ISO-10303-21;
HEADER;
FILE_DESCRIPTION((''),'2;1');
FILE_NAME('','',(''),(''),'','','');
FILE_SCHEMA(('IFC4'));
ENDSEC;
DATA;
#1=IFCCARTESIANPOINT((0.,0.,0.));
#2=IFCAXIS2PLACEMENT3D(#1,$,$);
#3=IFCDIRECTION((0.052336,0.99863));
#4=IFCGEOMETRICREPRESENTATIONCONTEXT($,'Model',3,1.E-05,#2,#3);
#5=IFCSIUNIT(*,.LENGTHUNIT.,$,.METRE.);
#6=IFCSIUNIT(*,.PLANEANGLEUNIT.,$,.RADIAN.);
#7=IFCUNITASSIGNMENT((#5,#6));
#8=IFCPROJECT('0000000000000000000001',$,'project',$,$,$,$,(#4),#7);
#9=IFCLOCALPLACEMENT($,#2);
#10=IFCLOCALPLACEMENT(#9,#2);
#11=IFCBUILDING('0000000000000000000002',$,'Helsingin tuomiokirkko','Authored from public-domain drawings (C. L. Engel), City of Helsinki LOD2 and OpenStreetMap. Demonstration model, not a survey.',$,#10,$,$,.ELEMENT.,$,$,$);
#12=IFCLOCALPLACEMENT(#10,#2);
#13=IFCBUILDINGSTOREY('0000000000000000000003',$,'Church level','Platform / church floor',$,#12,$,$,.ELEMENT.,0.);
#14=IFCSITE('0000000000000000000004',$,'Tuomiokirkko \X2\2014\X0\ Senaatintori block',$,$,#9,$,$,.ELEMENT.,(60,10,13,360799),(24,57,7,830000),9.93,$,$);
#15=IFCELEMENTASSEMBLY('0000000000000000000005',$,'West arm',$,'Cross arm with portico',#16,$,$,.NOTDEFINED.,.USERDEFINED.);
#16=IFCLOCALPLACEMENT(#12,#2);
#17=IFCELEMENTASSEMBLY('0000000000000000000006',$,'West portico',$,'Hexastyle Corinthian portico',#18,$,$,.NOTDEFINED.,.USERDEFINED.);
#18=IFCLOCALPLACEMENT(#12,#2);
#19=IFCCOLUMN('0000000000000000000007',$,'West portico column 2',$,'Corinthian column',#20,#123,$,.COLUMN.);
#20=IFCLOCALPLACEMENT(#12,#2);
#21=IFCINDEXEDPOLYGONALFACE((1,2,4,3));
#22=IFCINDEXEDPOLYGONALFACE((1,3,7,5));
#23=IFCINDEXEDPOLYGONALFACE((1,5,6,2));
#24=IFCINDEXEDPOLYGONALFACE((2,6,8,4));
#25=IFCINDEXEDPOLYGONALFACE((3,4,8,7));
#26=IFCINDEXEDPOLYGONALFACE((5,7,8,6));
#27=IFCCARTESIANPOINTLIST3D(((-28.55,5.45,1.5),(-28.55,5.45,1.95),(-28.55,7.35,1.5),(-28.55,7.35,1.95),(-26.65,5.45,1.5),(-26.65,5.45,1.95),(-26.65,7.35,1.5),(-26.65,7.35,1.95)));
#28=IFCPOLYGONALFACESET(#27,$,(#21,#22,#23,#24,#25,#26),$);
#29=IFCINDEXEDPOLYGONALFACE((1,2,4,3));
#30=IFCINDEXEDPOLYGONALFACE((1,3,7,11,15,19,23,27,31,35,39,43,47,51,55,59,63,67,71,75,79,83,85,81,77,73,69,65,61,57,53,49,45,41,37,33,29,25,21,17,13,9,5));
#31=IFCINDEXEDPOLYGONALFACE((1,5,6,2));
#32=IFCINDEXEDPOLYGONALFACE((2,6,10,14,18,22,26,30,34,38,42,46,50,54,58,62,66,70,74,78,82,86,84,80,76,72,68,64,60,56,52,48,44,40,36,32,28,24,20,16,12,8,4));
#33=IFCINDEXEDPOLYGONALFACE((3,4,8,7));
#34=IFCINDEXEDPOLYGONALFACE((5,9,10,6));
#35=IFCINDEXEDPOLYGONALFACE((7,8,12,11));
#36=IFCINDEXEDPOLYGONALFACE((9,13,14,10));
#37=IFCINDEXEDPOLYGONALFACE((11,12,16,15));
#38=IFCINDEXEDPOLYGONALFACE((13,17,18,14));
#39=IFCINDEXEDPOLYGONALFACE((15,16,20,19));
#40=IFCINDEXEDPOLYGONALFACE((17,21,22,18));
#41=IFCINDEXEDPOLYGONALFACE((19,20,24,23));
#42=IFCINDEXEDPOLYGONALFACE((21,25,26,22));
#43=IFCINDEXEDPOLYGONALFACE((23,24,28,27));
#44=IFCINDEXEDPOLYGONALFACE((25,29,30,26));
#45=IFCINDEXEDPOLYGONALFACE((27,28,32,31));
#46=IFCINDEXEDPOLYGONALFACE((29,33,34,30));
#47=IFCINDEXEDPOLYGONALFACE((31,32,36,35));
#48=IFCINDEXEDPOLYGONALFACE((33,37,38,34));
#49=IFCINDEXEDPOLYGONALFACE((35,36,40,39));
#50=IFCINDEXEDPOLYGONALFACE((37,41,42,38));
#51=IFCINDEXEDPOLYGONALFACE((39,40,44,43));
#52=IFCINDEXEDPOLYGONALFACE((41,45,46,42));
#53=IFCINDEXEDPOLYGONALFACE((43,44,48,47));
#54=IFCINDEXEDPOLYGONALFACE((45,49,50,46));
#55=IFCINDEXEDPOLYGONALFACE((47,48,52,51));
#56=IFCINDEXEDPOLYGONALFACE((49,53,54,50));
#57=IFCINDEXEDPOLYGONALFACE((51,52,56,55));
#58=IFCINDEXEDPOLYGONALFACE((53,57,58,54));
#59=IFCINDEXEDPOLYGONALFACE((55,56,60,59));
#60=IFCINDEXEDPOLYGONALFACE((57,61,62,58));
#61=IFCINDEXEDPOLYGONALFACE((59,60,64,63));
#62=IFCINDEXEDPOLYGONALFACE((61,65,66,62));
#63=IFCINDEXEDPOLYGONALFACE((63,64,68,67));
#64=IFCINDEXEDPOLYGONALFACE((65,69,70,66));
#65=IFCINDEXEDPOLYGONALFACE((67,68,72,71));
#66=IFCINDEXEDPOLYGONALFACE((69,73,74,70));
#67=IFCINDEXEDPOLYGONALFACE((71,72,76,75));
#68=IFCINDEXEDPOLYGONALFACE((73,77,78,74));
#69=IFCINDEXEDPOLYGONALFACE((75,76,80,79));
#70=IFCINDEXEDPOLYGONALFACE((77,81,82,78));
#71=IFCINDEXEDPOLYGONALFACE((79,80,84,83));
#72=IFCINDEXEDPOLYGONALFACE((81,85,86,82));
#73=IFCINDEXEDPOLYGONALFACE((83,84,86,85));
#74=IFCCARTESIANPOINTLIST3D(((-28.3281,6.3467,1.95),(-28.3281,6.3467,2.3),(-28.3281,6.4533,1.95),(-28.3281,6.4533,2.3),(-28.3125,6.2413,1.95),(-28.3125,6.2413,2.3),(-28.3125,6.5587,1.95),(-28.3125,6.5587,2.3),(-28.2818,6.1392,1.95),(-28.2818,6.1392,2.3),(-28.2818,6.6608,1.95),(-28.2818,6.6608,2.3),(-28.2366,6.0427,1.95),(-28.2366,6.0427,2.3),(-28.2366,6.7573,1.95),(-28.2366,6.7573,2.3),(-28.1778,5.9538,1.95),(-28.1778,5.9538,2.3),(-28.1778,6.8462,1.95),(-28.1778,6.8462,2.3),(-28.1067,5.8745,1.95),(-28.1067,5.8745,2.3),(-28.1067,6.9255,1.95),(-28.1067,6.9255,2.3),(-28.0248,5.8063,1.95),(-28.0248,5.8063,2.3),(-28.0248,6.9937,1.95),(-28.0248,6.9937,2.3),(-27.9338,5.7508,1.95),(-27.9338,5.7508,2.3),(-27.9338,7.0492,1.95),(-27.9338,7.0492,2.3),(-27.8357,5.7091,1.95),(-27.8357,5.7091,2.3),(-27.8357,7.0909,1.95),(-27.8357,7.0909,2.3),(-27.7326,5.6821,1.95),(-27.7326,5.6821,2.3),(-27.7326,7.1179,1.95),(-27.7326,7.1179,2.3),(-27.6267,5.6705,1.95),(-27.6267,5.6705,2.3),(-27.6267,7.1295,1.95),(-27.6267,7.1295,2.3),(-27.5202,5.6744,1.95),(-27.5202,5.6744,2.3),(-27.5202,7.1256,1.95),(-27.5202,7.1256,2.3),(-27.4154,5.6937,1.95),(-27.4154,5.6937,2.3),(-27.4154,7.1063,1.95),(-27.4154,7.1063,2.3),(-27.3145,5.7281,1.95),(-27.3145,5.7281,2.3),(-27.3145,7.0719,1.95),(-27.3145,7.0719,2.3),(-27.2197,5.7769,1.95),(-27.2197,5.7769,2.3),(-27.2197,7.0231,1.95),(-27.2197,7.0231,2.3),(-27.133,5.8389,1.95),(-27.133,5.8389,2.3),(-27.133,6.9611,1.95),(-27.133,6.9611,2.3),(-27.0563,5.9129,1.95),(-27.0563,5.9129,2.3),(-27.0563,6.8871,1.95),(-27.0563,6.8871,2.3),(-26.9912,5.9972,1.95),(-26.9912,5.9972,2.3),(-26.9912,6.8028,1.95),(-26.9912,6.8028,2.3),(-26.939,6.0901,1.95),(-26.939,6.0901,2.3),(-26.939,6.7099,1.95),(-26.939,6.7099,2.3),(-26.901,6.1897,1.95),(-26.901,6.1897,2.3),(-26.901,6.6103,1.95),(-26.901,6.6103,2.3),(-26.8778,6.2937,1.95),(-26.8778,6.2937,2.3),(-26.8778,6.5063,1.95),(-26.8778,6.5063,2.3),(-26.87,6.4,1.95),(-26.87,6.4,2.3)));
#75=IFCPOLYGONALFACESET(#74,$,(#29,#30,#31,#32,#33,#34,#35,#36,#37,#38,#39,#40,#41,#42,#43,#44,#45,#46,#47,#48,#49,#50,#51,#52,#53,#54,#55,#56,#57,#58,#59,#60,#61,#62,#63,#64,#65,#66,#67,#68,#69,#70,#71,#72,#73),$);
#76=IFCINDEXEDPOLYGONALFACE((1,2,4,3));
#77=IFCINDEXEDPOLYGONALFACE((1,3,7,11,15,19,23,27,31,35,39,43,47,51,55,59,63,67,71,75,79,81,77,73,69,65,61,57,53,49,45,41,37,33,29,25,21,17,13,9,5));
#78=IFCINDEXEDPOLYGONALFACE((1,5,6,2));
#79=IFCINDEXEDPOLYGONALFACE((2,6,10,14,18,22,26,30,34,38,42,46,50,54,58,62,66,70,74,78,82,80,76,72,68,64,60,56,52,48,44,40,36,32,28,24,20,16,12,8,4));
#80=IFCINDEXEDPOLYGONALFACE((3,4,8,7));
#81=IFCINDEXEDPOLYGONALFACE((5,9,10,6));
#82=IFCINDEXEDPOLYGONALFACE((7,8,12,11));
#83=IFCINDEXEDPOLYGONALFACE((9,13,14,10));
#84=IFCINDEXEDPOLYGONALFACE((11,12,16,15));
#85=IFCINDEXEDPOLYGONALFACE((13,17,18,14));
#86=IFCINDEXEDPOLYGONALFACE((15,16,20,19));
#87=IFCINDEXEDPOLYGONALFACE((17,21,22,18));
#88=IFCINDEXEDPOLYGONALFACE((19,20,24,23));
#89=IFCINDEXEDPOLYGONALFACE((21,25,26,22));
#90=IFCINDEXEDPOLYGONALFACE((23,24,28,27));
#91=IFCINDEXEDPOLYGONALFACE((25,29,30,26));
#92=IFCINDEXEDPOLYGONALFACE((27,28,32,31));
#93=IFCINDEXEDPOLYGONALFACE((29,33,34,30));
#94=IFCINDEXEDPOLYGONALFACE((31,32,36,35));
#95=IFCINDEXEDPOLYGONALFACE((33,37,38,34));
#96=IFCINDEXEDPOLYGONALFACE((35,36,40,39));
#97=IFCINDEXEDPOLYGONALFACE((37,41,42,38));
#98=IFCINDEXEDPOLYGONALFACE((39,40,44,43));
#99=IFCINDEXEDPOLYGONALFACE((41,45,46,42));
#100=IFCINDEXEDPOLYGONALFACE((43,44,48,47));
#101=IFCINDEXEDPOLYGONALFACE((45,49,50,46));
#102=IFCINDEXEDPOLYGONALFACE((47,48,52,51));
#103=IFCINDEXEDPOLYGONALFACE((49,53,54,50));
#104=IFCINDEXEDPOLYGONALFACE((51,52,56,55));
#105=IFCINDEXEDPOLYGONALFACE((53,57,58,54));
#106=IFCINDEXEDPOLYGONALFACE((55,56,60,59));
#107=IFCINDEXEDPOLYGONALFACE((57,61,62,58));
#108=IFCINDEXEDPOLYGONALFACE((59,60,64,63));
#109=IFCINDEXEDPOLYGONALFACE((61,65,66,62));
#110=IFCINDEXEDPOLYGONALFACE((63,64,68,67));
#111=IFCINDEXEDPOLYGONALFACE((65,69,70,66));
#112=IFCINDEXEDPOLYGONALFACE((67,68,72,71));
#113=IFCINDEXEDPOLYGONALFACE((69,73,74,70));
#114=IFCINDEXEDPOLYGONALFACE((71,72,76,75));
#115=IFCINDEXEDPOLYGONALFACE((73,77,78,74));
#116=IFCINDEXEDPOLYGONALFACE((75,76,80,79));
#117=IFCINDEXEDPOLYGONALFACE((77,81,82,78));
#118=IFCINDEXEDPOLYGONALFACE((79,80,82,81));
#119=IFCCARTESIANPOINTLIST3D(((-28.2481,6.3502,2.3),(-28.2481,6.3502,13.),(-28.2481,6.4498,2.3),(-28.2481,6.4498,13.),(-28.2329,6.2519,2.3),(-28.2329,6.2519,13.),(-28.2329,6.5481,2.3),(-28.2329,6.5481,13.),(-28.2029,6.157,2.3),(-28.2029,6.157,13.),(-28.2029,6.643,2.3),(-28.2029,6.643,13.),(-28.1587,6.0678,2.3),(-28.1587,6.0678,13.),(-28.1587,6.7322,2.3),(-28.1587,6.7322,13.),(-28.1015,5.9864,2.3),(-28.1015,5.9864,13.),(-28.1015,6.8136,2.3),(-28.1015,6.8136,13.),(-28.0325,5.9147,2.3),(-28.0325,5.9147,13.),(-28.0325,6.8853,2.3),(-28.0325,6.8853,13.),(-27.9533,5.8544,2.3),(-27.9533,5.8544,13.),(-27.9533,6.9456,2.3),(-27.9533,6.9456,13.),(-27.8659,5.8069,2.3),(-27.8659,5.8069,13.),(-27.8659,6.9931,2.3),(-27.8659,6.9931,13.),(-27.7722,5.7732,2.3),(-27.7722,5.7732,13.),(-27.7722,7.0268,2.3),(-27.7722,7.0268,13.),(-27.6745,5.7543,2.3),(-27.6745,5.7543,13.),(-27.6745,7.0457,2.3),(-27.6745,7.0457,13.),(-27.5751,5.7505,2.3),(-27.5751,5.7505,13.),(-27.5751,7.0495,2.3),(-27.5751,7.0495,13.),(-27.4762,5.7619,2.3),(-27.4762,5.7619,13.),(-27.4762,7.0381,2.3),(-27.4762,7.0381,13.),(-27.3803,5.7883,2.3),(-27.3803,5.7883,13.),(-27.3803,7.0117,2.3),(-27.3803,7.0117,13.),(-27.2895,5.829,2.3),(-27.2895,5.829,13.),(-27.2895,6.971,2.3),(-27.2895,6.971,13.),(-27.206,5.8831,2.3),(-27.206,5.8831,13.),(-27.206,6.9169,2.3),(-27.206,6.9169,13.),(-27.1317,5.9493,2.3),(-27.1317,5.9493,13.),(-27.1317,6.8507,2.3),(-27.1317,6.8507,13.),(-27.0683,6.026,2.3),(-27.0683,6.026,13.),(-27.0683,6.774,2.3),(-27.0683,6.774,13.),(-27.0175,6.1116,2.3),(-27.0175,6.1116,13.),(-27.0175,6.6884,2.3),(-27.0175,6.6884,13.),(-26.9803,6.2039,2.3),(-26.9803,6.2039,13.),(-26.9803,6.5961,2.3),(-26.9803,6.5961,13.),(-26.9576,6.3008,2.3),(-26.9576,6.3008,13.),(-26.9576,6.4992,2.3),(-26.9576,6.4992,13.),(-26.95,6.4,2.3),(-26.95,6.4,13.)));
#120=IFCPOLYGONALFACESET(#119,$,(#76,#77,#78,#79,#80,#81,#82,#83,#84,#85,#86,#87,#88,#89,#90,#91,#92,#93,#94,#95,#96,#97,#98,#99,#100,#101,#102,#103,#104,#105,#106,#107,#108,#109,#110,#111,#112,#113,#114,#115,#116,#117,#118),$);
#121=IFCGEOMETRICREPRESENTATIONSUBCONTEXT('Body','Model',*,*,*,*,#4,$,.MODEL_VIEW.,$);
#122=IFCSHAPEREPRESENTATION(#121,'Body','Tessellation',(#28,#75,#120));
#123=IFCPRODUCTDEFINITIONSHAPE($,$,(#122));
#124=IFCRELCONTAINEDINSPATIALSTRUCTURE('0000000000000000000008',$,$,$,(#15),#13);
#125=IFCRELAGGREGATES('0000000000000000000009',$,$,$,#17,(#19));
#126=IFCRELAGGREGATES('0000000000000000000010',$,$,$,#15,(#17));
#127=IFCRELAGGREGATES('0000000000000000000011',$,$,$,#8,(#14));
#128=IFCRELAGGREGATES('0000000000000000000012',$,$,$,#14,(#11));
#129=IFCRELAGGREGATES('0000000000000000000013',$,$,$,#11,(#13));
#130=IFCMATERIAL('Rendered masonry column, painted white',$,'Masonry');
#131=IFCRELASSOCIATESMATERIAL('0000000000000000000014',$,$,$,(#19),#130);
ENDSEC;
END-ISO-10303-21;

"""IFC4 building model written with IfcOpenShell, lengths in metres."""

from ifc_helpers import new_model, si_unit, direction, frame, origin, origin_2d_with_axis, place, context, subcontext, project, spatial, rectangle, circle, extrude, material, element, aggregate, save


model = new_model("IFC4")

# Units and contexts
model_context = context("Model", 3, precision=1e-05, world=origin(), true_north=direction((0.052336, 0.99863)))
body_context = subcontext(model_context, "Body", "Model", "MODEL_VIEW")
ifc_project = project(units=[si_unit("LENGTHUNIT", "METRE"), si_unit("PLANEANGLEUNIT", "RADIAN")], contexts=[model_context])

# Site, building, storey
site_placement = place(None, origin())
site = spatial("IfcSite", under=ifc_project, at=site_placement, Name="Tuomiokirkko — Senaatintori block", CompositionType="ELEMENT", RefLatitude=(60, 10, 13, 360799), RefLongitude=(24, 57, 7, 830000), RefElevation=9.93)
building_placement = place(site_placement, origin())
building = spatial("IfcBuilding", under=site, at=building_placement, Name="Helsingin tuomiokirkko", Description="Authored from public-domain drawings (C. L. Engel), City of Helsinki LOD2 and OpenStreetMap. Demonstration model, not a survey.", CompositionType="ELEMENT")
storey_placement = place(building_placement, origin())
storey = spatial("IfcBuildingStorey", under=building, at=storey_placement, Name="Church level", Description="Platform / church floor", CompositionType="ELEMENT", Elevation=0.0)

# Element assemblies, column
assembly_1_placement = place(building_placement, origin())
assembly_1 = element("IfcElementAssembly", 1, at=assembly_1_placement, inside=storey, Name="West arm", ObjectType="Cross arm with portico", AssemblyPlace="NOTDEFINED", PredefinedType="USERDEFINED")
assembly_2_placement = place(building_placement, origin())
assembly_2 = element("IfcElementAssembly", 2, at=assembly_2_placement, Name="West portico", ObjectType="Hexastyle Corinthian portico", AssemblyPlace="NOTDEFINED", PredefinedType="USERDEFINED")
ifc_material_1 = material(Name="Rendered masonry column, painted white", Category="Masonry")
column_1_placement = place(building_placement, origin())
column_1 = element("IfcColumn", 3, at=column_1_placement, material=ifc_material_1, Name="West portico column 2", ObjectType="Corinthian column", PredefinedType="COLUMN", context=body_context, shape_type="SweptSolid", body=[
    extrude(rectangle(XDim=1.9, YDim=1.9, at=origin_2d_with_axis()), frame((-27.6, 6.4, 1.5)), (0.0, 0.0, 1.0), 0.45),
    extrude(circle(Radius=0.73, at=origin_2d_with_axis()), frame((-27.6, 6.4, 1.95)), (0.0, 0.0, 1.0), 0.35),
    extrude(circle(Radius=0.65, at=origin_2d_with_axis()), frame((-27.6, 6.4, 2.3)), (0.0, 0.0, 1.0), 10.7),
])

aggregate(assembly_2, [column_1])

aggregate(assembly_1, [assembly_2])

save(model, "model.ifc")
